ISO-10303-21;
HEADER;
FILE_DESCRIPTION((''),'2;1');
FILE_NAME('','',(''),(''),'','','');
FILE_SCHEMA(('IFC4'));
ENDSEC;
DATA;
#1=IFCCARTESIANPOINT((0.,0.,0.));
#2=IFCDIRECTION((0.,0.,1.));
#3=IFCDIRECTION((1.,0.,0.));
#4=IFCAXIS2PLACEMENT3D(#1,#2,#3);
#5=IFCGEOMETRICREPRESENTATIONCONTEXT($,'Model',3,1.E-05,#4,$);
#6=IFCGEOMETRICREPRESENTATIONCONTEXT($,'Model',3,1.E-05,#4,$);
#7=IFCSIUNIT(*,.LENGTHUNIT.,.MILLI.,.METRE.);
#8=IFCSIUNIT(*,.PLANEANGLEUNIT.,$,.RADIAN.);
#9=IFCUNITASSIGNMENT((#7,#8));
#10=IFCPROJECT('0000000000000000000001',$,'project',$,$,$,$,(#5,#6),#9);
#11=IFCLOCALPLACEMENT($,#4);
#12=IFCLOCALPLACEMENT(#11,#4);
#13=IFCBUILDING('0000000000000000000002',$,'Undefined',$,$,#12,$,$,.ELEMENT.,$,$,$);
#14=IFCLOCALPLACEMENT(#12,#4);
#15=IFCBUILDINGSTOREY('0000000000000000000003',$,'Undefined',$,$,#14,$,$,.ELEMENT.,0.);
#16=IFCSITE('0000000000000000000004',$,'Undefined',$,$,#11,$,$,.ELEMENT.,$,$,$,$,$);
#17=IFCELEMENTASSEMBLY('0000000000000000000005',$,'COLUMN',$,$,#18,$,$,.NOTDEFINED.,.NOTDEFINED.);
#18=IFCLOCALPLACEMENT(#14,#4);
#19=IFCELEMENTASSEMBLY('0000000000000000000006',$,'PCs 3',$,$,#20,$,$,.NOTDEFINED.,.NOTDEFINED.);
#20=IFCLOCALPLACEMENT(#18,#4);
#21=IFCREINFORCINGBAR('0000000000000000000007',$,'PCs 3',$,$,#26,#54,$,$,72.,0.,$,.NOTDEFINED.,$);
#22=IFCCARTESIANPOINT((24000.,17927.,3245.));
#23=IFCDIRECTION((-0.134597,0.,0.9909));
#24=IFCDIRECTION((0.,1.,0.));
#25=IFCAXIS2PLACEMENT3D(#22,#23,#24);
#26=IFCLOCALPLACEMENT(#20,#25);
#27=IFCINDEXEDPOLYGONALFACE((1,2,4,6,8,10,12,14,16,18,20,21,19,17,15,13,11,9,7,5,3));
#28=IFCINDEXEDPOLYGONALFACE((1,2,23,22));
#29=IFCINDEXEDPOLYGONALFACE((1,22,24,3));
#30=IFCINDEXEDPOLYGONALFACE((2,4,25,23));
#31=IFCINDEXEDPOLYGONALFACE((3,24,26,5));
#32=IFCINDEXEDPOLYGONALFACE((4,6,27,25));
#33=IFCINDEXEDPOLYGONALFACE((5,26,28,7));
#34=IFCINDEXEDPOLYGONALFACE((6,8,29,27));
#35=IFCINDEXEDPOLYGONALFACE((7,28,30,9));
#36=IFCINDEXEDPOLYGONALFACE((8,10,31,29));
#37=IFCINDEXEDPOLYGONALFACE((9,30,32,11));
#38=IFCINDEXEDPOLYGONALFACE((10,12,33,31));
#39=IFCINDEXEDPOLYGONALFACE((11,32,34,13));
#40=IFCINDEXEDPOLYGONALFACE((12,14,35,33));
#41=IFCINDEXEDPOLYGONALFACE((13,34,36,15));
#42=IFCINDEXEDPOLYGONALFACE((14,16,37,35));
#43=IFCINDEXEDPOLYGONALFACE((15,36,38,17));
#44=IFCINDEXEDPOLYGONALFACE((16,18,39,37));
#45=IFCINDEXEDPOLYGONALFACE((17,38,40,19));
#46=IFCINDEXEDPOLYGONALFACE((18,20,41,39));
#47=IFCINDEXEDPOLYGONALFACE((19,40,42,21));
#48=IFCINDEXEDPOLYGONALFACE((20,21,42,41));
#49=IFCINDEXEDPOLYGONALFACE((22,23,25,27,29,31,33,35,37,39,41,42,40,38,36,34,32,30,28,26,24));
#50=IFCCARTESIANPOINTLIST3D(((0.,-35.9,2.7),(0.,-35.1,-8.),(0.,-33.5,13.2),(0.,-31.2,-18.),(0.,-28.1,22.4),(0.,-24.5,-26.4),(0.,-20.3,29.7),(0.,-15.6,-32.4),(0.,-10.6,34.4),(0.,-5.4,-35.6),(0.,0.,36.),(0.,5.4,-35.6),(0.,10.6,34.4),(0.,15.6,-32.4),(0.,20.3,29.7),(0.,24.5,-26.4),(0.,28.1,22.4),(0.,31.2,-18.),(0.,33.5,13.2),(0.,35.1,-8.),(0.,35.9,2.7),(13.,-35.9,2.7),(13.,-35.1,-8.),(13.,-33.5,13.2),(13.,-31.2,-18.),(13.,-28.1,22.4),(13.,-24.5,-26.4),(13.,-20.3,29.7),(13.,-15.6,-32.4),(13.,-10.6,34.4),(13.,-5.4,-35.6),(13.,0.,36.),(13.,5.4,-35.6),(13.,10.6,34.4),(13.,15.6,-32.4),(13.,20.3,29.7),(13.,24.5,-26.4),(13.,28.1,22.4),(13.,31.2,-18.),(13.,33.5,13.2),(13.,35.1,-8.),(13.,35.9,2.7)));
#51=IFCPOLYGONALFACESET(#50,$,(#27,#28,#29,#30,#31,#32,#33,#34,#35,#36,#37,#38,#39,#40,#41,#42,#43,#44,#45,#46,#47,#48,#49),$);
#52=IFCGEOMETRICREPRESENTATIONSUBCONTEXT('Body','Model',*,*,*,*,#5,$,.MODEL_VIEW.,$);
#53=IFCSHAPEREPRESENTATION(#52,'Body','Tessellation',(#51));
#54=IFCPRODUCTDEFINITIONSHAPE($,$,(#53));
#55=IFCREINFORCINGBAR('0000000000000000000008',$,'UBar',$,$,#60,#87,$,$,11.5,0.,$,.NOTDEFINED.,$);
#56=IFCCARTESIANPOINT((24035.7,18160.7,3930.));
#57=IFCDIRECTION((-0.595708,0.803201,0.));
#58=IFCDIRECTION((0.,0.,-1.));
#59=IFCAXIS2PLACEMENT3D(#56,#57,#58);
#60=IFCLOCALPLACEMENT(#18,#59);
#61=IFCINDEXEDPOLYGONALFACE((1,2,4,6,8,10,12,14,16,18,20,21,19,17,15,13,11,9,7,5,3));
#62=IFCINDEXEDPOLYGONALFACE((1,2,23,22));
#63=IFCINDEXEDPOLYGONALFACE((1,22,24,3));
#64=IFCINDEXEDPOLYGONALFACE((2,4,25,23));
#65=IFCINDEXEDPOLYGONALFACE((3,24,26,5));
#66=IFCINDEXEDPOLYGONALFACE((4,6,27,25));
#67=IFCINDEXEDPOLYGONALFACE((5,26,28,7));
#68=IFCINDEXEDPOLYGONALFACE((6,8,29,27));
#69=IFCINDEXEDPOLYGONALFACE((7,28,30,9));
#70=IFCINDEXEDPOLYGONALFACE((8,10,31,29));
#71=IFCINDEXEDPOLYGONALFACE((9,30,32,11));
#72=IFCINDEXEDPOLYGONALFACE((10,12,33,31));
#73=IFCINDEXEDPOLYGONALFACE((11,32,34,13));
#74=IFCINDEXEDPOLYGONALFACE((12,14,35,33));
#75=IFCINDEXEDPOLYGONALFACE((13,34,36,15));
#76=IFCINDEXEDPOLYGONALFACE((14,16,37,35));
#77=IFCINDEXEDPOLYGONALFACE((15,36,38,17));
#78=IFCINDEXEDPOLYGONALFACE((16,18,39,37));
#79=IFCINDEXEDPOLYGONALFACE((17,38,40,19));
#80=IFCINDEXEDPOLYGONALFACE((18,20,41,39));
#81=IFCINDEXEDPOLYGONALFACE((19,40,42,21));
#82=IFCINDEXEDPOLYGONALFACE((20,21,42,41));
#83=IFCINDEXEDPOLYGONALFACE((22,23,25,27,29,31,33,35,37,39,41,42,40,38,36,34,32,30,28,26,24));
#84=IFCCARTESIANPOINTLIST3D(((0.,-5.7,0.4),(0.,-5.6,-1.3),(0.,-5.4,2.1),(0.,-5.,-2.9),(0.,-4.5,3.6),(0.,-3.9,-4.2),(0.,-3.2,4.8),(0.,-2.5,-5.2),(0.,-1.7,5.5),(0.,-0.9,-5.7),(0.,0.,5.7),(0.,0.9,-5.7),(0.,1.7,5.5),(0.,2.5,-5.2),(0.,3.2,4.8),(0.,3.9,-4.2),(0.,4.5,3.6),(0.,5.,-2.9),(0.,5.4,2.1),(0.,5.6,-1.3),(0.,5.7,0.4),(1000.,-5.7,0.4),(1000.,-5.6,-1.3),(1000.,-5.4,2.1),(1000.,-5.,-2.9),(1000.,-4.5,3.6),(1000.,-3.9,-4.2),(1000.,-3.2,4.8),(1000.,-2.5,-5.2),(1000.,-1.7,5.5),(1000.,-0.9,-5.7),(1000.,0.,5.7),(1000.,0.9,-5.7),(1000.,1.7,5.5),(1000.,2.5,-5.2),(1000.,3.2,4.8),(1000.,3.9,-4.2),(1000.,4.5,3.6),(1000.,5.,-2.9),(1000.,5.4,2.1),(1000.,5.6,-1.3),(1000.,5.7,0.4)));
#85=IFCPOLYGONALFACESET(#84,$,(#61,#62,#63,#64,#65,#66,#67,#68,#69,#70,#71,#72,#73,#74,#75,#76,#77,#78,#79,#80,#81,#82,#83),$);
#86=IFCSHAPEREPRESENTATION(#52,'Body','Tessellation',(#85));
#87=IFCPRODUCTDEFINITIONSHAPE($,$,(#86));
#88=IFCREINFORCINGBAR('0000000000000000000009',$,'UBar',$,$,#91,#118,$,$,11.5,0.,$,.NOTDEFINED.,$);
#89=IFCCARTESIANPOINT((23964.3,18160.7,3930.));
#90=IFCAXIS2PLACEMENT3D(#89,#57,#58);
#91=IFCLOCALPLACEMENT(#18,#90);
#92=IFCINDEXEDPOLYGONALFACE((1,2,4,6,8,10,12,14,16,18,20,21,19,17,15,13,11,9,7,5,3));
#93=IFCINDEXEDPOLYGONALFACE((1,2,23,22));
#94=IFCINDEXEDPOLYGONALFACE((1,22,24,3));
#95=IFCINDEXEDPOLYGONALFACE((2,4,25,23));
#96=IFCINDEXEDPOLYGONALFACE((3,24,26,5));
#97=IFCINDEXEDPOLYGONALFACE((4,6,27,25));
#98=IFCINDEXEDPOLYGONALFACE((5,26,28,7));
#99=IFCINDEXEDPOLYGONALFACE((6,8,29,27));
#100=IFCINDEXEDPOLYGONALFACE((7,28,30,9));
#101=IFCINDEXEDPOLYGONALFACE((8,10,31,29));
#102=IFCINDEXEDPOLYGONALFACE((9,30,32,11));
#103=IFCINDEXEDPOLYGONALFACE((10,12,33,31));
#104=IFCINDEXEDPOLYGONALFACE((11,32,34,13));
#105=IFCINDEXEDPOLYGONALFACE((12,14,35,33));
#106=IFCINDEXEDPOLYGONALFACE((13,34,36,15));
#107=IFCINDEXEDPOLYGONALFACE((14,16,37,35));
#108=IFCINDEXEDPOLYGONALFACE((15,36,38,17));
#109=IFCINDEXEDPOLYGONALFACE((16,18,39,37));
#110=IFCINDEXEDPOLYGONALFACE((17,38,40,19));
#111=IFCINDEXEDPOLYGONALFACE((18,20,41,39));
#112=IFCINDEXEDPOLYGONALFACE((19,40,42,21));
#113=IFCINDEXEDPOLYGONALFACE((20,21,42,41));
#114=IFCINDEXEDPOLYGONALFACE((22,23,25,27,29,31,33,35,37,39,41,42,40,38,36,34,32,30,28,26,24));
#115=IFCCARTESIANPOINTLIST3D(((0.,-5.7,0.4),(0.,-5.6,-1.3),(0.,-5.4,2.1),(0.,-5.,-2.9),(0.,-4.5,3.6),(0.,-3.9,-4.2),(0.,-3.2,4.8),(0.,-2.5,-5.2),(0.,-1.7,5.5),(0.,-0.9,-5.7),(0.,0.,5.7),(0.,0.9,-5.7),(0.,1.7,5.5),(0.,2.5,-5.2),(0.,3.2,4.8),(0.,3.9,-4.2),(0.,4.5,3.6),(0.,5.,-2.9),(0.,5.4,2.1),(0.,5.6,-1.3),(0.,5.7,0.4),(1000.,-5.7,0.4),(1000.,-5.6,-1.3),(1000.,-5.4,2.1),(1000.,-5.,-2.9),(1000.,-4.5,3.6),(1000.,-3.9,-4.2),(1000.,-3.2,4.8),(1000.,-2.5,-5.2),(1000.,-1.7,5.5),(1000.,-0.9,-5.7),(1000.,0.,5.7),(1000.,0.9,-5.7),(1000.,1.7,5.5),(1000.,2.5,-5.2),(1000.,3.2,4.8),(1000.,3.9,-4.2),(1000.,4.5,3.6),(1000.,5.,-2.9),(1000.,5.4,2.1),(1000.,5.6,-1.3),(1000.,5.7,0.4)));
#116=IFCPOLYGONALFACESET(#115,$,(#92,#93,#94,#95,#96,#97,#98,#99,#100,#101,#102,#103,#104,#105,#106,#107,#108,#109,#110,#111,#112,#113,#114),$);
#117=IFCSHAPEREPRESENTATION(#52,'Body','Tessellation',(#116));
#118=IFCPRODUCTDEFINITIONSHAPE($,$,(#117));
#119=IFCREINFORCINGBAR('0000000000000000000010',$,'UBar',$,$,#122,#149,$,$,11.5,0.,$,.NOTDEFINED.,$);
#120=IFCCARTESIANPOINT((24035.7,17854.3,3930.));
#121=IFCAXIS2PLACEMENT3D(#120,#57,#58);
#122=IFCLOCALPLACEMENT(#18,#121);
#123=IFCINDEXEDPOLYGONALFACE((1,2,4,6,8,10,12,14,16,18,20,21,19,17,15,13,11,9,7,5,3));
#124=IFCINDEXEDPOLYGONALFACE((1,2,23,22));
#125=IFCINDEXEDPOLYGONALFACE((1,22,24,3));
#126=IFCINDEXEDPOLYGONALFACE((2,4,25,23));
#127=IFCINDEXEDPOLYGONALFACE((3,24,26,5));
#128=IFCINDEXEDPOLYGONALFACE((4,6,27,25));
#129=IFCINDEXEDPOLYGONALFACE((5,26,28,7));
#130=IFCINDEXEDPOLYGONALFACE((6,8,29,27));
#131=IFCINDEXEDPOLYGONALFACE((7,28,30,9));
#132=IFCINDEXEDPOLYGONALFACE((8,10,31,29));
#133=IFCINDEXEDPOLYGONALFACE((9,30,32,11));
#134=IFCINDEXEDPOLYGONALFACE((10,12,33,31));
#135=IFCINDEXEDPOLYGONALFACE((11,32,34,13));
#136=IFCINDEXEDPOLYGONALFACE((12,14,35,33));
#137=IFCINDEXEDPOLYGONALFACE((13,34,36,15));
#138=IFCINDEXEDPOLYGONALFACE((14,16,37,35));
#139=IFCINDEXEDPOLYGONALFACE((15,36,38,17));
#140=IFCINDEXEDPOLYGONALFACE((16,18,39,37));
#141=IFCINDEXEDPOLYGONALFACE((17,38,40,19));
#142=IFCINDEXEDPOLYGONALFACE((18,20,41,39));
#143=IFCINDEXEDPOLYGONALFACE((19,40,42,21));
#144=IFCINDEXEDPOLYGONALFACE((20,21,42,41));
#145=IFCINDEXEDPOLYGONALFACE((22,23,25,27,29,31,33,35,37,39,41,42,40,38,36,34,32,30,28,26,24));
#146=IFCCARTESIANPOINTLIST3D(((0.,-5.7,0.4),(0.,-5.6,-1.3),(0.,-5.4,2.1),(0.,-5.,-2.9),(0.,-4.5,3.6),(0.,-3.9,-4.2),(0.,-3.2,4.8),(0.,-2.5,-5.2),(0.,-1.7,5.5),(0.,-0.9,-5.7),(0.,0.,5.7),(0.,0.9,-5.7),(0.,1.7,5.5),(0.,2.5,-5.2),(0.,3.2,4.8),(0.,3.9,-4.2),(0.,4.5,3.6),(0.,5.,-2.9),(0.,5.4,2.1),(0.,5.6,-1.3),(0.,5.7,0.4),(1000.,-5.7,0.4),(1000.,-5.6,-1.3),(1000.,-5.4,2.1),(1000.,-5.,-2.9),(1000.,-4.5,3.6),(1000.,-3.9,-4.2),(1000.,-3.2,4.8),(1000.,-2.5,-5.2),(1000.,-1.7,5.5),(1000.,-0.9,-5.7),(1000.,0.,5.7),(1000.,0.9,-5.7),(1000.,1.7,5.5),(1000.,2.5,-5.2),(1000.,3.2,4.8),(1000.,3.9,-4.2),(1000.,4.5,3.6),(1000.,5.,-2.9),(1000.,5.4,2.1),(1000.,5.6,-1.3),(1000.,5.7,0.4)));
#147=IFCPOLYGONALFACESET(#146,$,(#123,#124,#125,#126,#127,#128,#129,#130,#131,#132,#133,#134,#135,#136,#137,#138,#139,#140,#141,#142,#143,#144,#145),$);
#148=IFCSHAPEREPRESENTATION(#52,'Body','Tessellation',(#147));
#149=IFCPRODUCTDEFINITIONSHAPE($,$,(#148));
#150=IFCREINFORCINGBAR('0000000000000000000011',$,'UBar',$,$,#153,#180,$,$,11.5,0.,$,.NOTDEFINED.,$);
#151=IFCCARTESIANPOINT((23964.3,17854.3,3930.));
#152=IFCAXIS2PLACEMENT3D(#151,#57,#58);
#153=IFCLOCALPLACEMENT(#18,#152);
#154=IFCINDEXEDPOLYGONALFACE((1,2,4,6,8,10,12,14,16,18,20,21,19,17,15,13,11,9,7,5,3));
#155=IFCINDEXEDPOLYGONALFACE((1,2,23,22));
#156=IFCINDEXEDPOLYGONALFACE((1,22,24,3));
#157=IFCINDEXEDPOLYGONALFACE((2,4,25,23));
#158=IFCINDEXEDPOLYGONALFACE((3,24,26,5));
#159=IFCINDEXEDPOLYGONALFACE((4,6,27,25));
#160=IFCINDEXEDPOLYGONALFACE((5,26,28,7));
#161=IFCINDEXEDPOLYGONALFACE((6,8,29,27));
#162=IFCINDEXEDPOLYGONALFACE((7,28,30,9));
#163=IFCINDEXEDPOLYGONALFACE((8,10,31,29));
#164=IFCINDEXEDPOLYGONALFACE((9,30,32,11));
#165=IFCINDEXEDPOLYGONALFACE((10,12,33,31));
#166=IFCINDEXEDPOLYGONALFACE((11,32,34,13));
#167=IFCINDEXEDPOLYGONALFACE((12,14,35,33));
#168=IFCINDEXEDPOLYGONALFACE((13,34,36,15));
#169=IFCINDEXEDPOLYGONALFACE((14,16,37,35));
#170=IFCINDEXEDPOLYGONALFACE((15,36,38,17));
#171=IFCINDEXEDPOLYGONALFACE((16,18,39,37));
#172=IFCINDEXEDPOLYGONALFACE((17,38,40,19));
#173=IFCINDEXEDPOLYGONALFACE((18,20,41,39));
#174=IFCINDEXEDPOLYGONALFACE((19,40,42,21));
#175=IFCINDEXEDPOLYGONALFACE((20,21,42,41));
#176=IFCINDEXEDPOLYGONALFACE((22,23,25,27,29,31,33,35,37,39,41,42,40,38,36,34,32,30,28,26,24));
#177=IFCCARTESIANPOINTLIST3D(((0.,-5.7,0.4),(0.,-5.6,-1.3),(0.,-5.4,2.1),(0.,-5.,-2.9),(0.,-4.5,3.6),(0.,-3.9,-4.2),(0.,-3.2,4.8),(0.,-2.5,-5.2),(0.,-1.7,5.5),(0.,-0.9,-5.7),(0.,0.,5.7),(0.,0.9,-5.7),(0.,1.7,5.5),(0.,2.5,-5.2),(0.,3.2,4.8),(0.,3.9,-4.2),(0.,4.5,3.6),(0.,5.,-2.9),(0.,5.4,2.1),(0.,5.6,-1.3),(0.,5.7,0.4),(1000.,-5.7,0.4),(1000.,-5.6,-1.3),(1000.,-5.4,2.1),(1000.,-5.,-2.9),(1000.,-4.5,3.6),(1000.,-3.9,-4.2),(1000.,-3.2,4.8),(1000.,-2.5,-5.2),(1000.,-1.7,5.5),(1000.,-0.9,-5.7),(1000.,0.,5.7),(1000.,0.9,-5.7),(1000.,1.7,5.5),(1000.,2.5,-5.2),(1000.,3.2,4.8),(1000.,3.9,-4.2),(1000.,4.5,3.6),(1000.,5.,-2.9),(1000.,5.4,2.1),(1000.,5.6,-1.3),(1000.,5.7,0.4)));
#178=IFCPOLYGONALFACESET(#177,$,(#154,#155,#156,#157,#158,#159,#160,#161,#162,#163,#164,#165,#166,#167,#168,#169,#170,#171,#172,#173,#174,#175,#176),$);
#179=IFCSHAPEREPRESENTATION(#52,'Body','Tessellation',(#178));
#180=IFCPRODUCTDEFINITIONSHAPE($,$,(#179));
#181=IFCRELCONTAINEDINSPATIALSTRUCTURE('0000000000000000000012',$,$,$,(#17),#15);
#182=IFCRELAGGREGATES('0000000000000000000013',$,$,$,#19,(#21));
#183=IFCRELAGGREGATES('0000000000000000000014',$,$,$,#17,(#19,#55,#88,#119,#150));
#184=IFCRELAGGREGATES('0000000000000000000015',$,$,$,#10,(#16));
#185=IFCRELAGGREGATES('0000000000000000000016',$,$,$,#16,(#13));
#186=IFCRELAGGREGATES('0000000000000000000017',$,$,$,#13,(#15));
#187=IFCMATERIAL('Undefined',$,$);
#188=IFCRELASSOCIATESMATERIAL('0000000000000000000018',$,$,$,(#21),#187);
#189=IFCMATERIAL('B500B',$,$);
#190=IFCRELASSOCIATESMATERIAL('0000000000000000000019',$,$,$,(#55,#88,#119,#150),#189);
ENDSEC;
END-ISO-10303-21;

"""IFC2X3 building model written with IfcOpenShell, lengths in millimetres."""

from ifc_helpers import new_model, entity, si_unit, frame, origin_with_axes, place, context, subcontext, project, spatial, source, transform, mapped, material, element, aggregate, save


model = new_model("IFC2X3")

# Units and contexts
model_context_1 = context("Model", 3, precision=1e-05, world=origin_with_axes())
model_context_2 = context("Model", 3, precision=1e-05, world=origin_with_axes())
body_context = subcontext(model_context_1, "Body", "Model", "MODEL_VIEW")
ifc_project = project(units=[si_unit("LENGTHUNIT", "METRE", prefix="MILLI"), si_unit("PLANEANGLEUNIT", "RADIAN")], contexts=[model_context_1, model_context_2])

# Site, building, storey
site_placement = place(None, origin_with_axes())
site = spatial("IfcSite", under=ifc_project, at=site_placement, Name="Undefined", CompositionType="ELEMENT")
building_placement = place(site_placement, origin_with_axes())
building = spatial("IfcBuilding", under=site, at=building_placement, Name="Undefined", CompositionType="ELEMENT")
storey_placement = place(building_placement, origin_with_axes())
storey = spatial("IfcBuildingStorey", under=building, at=storey_placement, Name="Undefined", CompositionType="ELEMENT", Elevation=0.0)

# Element assemblies
assembly_1_placement = place(storey_placement, origin_with_axes())
assembly_1 = element("IfcElementAssembly", 1, at=assembly_1_placement, inside=storey, Name="COLUMN", AssemblyPlace="NOTDEFINED", PredefinedType="NOTDEFINED")
assembly_2_placement = place(assembly_1_placement, origin_with_axes())
assembly_2 = element("IfcElementAssembly", 2, at=assembly_2_placement, Name="PCs 3", AssemblyPlace="NOTDEFINED", PredefinedType="NOTDEFINED")

# Reinforcing bars
ifc_material_1 = material(Name="Undefined")
shared_shape_1 = source(origin_with_axes(), body_context, "Body", "AdvancedSweptSolid", [
    entity("IfcSweptDiskSolid", entity("IfcTrimmedCurve", entity("IfcLine", entity("IfcCartesianPoint", [0.0, 0.0, 0.0]), entity("IfcVector", entity("IfcDirection", [1.0, 0.0, 0.0]), 1.0)), [entity("IfcParameterValue", 0.0)], [entity("IfcParameterValue", 13.0)], True, "PARAMETER"), 36.0, None, 0.0, 13.0),
])
reinforcing_bar_1_placement = place(assembly_2_placement, frame((24000.0, 17927.0, 3245.0), z_axis=(-0.134597, 0.0, 0.9909), x_axis=(0.0, 1.0, 0.0)))
reinforcing_bar_1 = element("IfcReinforcingBar", 3, at=reinforcing_bar_1_placement, material=ifc_material_1, Name="PCs 3", BarRole="NOTDEFINED", CrossSectionArea=0.0, NominalDiameter=72.0, context=body_context, shape_type="MappedRepresentation", body=[
    mapped(shared_shape_1, transform((0.0, 0.0, 0.0))),
])
aggregate(assembly_2, [reinforcing_bar_1])
ifc_material_2 = material(Name="B500B")
shared_shape_2 = source(origin_with_axes(), body_context, "Body", "AdvancedSweptSolid", [
    entity("IfcSweptDiskSolid", entity("IfcTrimmedCurve", entity("IfcLine", entity("IfcCartesianPoint", [0.0, 0.0, 0.0]), entity("IfcVector", entity("IfcDirection", [1.0, 0.0, 0.0]), 1.0)), [entity("IfcParameterValue", 0.0)], [entity("IfcParameterValue", 1000.0)], True, "PARAMETER"), 5.8, None, 0.0, 1000.0),
])
reinforcing_bar_2_placement = place(assembly_1_placement, frame((24035.7, 18160.7, 3930.0), z_axis=(-0.595708, 0.803201, 0.0), x_axis=(0.0, 0.0, -1.0)))
reinforcing_bar_2 = element("IfcReinforcingBar", 4, at=reinforcing_bar_2_placement, material=ifc_material_2, Name="UBar", BarRole="NOTDEFINED", CrossSectionArea=0.0, NominalDiameter=11.5, context=body_context, shape_type="MappedRepresentation", body=[
    mapped(shared_shape_2, transform((0.0, 0.0, 0.0))),
])
shared_shape_3 = source(origin_with_axes(), body_context, "Body", "AdvancedSweptSolid", [
    entity("IfcSweptDiskSolid", entity("IfcTrimmedCurve", entity("IfcLine", entity("IfcCartesianPoint", [0.0, 0.0, 0.0]), entity("IfcVector", entity("IfcDirection", [1.0, 0.0, 0.0]), 1.0)), [entity("IfcParameterValue", 0.0)], [entity("IfcParameterValue", 1000.0)], True, "PARAMETER"), 5.8, None, 0.0, 1000.0),
])
reinforcing_bar_3_placement = place(assembly_1_placement, frame((23964.3, 18160.7, 3930.0), z_axis=(-0.595708, 0.803201, 0.0), x_axis=(0.0, 0.0, -1.0)))
reinforcing_bar_3 = element("IfcReinforcingBar", 5, at=reinforcing_bar_3_placement, material=ifc_material_2, Name="UBar", BarRole="NOTDEFINED", CrossSectionArea=0.0, NominalDiameter=11.5, context=body_context, shape_type="MappedRepresentation", body=[
    mapped(shared_shape_3, transform((0.0, 0.0, 0.0))),
])
shared_shape_4 = source(origin_with_axes(), body_context, "Body", "AdvancedSweptSolid", [
    entity("IfcSweptDiskSolid", entity("IfcTrimmedCurve", entity("IfcLine", entity("IfcCartesianPoint", [0.0, 0.0, 0.0]), entity("IfcVector", entity("IfcDirection", [1.0, 0.0, 0.0]), 1.0)), [entity("IfcParameterValue", 0.0)], [entity("IfcParameterValue", 1000.0)], True, "PARAMETER"), 5.8, None, 0.0, 1000.0),
])
reinforcing_bar_4_placement = place(assembly_1_placement, frame((24035.7, 17854.3, 3930.0), z_axis=(-0.595708, 0.803201, 0.0), x_axis=(0.0, 0.0, -1.0)))
reinforcing_bar_4 = element("IfcReinforcingBar", 6, at=reinforcing_bar_4_placement, material=ifc_material_2, Name="UBar", BarRole="NOTDEFINED", CrossSectionArea=0.0, NominalDiameter=11.5, context=body_context, shape_type="MappedRepresentation", body=[
    mapped(shared_shape_4, transform((0.0, 0.0, 0.0))),
])
shared_shape_5 = source(origin_with_axes(), body_context, "Body", "AdvancedSweptSolid", [
    entity("IfcSweptDiskSolid", entity("IfcTrimmedCurve", entity("IfcLine", entity("IfcCartesianPoint", [0.0, 0.0, 0.0]), entity("IfcVector", entity("IfcDirection", [1.0, 0.0, 0.0]), 1.0)), [entity("IfcParameterValue", 0.0)], [entity("IfcParameterValue", 1000.0)], True, "PARAMETER"), 5.8, None, 0.0, 1000.0),
])
reinforcing_bar_5_placement = place(assembly_1_placement, frame((23964.3, 17854.3, 3930.0), z_axis=(-0.595708, 0.803201, 0.0), x_axis=(0.0, 0.0, -1.0)))
reinforcing_bar_5 = element("IfcReinforcingBar", 7, at=reinforcing_bar_5_placement, material=ifc_material_2, Name="UBar", BarRole="NOTDEFINED", CrossSectionArea=0.0, NominalDiameter=11.5, context=body_context, shape_type="MappedRepresentation", body=[
    mapped(shared_shape_5, transform((0.0, 0.0, 0.0))),
])
aggregate(assembly_1, [assembly_2, reinforcing_bar_2, reinforcing_bar_3, reinforcing_bar_4, reinforcing_bar_5])

save(model, "model.ifc")
